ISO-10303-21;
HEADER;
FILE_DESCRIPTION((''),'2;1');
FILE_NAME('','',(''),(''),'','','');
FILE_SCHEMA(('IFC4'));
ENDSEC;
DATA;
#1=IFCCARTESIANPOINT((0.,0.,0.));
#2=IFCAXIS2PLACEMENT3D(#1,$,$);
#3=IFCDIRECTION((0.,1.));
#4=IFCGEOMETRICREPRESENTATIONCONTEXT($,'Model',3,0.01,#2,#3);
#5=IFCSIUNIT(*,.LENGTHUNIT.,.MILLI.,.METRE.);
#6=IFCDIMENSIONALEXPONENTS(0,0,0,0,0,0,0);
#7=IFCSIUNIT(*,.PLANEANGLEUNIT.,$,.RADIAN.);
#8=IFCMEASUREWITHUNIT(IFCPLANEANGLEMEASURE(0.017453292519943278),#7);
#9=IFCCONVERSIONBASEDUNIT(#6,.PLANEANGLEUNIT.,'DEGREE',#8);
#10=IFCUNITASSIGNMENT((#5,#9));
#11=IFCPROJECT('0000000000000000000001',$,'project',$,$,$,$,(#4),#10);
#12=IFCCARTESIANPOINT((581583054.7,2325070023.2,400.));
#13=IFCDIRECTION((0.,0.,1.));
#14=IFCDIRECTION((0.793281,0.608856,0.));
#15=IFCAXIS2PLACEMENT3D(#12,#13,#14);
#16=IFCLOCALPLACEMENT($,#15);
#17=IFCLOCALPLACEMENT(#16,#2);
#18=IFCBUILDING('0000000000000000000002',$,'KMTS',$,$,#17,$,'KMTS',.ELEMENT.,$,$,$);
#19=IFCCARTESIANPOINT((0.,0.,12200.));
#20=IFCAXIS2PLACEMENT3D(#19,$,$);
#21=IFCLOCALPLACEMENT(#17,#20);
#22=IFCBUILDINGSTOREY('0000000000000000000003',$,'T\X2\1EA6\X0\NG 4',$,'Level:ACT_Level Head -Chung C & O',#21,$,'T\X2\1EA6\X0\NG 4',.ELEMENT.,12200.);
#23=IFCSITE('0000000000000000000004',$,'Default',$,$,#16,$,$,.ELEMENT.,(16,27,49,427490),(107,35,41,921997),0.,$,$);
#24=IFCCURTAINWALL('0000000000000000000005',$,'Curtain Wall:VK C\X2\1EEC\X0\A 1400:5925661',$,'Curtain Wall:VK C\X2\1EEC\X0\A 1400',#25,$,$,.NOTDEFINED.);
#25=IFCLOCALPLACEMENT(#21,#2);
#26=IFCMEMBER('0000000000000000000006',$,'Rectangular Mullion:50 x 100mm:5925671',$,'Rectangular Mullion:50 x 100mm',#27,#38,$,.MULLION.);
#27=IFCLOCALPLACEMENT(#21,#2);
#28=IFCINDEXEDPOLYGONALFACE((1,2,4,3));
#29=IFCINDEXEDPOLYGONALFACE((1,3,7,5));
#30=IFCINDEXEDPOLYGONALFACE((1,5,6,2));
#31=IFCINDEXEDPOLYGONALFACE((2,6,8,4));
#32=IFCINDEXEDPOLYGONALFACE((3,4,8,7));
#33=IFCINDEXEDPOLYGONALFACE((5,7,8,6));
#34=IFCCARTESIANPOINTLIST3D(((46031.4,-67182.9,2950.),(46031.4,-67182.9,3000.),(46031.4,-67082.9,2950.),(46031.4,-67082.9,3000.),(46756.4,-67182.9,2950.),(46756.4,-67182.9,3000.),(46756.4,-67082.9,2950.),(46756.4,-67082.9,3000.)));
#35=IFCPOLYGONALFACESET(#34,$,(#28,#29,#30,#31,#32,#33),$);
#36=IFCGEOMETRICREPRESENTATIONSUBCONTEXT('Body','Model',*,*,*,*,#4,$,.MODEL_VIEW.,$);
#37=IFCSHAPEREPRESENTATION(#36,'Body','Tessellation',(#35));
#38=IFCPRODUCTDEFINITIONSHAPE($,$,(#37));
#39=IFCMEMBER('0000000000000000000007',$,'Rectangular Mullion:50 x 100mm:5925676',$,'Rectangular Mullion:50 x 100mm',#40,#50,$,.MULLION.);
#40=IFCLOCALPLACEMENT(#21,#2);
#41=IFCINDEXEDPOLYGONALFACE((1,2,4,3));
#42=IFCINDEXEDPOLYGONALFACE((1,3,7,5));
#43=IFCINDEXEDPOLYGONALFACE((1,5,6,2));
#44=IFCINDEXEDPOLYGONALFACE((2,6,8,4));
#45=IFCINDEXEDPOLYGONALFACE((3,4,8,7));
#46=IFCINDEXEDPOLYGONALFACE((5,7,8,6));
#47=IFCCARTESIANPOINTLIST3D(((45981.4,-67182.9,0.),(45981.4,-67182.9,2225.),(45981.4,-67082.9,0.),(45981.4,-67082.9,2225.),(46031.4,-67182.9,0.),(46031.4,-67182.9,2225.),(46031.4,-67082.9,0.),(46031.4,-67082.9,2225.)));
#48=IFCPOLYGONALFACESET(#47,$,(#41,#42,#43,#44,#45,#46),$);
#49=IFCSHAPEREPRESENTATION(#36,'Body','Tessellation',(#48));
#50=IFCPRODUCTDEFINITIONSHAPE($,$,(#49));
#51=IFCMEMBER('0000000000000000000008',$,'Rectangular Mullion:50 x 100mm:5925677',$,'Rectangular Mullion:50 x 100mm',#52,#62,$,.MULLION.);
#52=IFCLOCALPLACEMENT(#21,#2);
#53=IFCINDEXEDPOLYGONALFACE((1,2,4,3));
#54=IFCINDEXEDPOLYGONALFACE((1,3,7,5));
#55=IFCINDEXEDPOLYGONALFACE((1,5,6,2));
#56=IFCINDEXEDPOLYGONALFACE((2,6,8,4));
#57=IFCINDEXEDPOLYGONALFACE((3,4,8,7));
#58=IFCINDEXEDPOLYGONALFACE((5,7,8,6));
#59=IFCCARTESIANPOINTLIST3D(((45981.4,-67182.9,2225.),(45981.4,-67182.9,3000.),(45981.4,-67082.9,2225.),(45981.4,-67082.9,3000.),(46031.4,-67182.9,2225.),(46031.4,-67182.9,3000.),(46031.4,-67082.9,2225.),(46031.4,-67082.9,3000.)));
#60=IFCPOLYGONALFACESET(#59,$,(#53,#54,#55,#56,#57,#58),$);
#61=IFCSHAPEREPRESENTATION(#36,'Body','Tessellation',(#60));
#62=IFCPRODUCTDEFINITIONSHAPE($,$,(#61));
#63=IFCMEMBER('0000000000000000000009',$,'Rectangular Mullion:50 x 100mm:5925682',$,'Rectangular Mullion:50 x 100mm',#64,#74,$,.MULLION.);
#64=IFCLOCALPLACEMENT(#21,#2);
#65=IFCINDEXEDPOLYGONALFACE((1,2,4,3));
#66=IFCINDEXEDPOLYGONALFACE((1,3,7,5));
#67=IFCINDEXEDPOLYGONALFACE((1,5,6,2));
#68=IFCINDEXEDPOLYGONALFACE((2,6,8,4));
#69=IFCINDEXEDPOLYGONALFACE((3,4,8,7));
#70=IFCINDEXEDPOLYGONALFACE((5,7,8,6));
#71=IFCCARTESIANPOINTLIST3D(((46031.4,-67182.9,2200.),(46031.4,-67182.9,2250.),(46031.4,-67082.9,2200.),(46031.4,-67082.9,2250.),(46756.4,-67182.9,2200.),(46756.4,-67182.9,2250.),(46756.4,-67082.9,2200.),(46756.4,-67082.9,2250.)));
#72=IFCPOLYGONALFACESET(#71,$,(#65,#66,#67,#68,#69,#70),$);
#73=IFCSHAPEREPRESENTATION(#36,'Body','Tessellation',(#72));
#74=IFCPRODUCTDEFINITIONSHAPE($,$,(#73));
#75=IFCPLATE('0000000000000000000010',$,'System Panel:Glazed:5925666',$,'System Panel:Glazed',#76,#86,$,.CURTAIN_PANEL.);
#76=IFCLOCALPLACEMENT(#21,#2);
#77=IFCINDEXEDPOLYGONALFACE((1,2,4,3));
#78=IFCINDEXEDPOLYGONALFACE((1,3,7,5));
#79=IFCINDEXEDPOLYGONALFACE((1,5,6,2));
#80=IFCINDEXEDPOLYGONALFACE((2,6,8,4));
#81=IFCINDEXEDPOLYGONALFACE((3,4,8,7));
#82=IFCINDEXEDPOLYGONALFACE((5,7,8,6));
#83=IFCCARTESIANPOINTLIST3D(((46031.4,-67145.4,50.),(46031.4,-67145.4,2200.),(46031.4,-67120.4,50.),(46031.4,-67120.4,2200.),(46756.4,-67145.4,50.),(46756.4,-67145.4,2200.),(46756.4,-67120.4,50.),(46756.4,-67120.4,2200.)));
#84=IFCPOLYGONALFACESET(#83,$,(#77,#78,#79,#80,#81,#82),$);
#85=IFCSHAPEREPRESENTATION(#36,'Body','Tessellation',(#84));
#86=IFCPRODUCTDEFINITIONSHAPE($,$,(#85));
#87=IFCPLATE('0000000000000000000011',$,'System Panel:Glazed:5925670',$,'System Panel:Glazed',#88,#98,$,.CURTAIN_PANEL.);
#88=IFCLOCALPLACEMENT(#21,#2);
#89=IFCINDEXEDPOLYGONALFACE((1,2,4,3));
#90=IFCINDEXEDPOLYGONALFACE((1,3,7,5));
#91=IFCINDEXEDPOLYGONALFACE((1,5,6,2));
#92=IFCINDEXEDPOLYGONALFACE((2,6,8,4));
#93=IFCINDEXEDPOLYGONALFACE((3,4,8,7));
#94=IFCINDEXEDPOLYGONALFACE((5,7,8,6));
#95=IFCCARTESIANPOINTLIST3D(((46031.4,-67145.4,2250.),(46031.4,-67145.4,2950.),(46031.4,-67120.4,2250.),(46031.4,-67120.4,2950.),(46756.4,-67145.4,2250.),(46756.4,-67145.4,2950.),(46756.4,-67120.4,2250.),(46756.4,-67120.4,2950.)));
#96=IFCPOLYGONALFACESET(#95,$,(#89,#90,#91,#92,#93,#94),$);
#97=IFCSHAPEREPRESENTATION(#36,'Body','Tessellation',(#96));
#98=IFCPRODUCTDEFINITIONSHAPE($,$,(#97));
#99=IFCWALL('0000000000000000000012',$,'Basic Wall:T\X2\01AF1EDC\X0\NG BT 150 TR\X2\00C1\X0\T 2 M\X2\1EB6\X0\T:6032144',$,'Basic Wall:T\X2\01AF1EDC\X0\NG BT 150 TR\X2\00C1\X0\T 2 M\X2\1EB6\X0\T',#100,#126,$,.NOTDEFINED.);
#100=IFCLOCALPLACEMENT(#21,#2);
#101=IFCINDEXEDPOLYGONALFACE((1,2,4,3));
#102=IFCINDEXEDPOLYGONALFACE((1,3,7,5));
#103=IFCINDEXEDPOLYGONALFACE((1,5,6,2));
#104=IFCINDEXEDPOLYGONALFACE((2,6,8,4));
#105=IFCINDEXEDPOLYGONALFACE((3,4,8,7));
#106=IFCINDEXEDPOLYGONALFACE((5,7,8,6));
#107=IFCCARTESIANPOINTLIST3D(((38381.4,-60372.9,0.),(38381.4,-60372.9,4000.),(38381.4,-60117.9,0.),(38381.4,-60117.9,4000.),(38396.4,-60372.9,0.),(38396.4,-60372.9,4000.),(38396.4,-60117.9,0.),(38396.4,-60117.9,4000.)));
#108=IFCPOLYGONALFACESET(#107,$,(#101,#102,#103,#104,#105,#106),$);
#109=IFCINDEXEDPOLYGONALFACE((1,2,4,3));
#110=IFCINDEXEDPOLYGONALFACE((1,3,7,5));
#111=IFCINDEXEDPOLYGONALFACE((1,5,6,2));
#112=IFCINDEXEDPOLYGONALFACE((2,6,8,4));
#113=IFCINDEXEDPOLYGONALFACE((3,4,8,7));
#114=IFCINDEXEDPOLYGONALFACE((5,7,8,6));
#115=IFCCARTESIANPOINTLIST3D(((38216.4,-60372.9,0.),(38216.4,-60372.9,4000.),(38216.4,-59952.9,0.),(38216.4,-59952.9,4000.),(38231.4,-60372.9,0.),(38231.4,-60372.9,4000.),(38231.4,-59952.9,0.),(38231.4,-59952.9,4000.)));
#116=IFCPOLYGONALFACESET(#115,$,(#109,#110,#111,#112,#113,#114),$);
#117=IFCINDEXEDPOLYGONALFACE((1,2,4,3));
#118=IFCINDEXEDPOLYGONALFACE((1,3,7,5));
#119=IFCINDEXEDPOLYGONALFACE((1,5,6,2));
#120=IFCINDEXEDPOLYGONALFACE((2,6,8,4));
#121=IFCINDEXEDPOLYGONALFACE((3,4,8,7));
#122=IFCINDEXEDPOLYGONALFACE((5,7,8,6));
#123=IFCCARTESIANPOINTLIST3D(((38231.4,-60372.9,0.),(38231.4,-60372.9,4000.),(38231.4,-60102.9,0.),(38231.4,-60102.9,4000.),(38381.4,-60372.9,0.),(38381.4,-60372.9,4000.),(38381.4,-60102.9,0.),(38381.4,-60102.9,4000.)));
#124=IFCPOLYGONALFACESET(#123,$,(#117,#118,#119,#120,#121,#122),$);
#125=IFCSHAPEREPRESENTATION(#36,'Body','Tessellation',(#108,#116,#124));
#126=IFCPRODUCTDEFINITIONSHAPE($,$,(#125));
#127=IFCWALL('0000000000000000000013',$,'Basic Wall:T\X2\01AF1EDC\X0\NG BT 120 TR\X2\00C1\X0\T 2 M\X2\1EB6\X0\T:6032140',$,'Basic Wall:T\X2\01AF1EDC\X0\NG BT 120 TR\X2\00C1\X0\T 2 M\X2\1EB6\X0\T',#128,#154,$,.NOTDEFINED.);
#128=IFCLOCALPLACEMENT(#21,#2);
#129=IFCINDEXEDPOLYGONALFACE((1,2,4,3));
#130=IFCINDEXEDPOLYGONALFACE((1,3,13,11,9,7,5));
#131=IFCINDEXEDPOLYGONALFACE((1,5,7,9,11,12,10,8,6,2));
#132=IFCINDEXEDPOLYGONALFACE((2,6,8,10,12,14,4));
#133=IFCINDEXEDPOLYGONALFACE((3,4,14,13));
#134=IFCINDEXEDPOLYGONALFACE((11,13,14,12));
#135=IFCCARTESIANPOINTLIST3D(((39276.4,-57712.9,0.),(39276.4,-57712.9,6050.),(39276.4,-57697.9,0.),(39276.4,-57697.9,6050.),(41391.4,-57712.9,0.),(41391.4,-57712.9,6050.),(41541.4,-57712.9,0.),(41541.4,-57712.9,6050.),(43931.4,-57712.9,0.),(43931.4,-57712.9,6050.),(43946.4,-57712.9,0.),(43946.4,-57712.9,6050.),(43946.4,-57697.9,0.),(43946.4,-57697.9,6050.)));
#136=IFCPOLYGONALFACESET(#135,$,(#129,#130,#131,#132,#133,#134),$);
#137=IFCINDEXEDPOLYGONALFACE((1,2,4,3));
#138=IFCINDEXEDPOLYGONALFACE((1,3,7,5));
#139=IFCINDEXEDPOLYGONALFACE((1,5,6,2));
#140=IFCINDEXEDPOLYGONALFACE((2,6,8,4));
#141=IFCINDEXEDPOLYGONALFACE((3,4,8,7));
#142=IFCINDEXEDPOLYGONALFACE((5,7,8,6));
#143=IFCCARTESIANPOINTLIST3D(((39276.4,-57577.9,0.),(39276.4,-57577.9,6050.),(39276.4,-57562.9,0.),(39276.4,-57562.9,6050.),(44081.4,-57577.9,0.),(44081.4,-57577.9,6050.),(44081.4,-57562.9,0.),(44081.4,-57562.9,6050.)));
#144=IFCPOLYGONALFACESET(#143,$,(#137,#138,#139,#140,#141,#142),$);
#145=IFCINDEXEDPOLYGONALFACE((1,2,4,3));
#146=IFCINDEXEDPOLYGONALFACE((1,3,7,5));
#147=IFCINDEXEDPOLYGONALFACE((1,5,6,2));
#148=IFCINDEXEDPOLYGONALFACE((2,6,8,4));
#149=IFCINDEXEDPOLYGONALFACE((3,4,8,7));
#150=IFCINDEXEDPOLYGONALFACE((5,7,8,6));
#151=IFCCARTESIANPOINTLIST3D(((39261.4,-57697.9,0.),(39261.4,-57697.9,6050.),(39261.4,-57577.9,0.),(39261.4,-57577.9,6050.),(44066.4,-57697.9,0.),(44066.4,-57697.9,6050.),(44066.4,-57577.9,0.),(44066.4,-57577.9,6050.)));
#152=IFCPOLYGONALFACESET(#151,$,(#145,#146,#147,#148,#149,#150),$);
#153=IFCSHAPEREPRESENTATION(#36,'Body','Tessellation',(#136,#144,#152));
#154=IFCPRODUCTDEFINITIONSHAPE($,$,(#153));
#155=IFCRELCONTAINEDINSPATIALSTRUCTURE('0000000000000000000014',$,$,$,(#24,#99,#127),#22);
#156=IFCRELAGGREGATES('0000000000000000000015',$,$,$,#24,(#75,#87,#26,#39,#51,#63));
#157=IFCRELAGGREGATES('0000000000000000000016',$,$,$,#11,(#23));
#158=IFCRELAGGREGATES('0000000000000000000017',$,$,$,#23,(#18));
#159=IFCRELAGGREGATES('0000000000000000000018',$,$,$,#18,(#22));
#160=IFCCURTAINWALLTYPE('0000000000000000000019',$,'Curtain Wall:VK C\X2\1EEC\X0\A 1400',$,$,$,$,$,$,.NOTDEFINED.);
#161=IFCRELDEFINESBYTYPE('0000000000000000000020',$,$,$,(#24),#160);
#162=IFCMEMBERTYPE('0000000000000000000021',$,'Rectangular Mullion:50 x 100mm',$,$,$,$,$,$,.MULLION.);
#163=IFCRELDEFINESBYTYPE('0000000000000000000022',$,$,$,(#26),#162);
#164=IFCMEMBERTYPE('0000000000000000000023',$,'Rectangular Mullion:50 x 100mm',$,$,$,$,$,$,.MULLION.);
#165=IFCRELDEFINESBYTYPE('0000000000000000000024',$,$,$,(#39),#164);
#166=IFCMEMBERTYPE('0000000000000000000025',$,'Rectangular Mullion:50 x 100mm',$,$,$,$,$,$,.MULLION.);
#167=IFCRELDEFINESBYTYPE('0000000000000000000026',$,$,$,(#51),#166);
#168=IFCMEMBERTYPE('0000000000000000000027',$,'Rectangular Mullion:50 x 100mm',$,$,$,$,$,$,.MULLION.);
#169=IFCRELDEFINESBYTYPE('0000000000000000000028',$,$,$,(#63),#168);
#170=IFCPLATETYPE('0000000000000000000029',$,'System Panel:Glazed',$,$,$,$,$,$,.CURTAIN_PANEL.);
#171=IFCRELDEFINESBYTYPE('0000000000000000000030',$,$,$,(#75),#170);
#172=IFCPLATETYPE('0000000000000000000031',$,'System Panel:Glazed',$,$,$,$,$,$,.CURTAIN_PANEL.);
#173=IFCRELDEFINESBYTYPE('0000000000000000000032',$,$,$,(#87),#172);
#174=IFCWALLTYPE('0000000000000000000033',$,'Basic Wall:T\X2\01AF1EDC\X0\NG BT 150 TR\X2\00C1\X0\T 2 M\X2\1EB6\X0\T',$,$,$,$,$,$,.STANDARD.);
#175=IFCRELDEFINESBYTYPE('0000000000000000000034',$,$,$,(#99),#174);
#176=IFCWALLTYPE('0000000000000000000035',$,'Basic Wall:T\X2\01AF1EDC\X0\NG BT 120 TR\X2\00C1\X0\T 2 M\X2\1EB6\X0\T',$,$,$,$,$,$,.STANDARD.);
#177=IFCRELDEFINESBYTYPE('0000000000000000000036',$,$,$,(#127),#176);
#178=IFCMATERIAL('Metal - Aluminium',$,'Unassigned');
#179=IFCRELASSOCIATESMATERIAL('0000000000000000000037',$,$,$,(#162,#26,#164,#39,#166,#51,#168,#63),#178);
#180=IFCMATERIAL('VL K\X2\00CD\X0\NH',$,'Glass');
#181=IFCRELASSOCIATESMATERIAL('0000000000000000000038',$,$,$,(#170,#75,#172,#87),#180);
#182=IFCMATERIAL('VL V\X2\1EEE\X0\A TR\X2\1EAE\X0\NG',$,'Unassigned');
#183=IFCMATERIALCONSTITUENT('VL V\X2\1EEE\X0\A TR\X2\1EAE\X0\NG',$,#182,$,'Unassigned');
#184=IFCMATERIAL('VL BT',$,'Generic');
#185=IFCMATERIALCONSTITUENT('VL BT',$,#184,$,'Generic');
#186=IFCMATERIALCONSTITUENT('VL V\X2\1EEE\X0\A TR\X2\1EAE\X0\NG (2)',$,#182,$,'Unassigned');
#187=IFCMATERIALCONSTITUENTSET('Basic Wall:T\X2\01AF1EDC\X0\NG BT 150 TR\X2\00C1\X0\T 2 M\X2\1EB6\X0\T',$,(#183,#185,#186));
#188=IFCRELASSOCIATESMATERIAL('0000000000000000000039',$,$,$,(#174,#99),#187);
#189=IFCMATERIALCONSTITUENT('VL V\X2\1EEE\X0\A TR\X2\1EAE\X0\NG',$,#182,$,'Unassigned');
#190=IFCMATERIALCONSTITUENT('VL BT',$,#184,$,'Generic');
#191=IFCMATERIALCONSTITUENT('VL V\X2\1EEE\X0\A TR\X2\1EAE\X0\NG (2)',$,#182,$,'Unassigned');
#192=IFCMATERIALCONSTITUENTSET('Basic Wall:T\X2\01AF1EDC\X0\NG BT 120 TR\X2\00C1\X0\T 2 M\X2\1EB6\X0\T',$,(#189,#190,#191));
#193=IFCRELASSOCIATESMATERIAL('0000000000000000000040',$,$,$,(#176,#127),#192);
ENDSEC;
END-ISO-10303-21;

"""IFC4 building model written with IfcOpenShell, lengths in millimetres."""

from ifc_helpers import new_model, entity, si_unit, converted_unit, direction, frame, origin, place, context, subcontext, project, spatial, indexed_curve, outline, extrude, source, transform, mapped, material, constituent, constituent_set, type_object, type_shapes, element, aggregate, save


model = new_model("IFC4")

# Units and contexts
model_context = context("Model", 3, precision=0.01, world=origin(), true_north=direction((0.0, 1.0)))
body_context = subcontext(model_context, "Body", "Model", "MODEL_VIEW")
ifc_project = project(units=[si_unit("LENGTHUNIT", "METRE", prefix="MILLI"), converted_unit("PLANEANGLEUNIT", "DEGREE", entity("IfcPlaneAngleMeasure", 0.017453292519943278), si_unit("PLANEANGLEUNIT", "RADIAN"), dimensions=[0, 0, 0, 0, 0, 0, 0])], contexts=[model_context])

# Site, building, storey
site_placement = place(None, frame((581583054.7, 2325070023.2, 400.0), z_axis=(0.0, 0.0, 1.0), x_axis=(0.793281, 0.608856, 0.0)))
site = spatial("IfcSite", under=ifc_project, at=site_placement, Name="Default", CompositionType="ELEMENT", RefLatitude=(16, 27, 49, 427490), RefLongitude=(107, 35, 41, 921997), RefElevation=0.0)
building_placement = place(site_placement, origin())
building = spatial("IfcBuilding", under=site, at=building_placement, Name="KMTS", LongName="KMTS", CompositionType="ELEMENT")
storey_placement = place(building_placement, frame((0.0, 0.0, 12200.0)))
storey = spatial("IfcBuildingStorey", under=building, at=storey_placement, Name="TẦNG 4", ObjectType="Level:ACT_Level Head -Chung C & O", LongName="TẦNG 4", CompositionType="ELEMENT", Elevation=12200.0)

# Curtain wall, members, plates
curtain_wall_type = type_object("IfcCurtainWallType", Name="Curtain Wall:VK CỬA 1400", PredefinedType="NOTDEFINED")
curtain_wall_placement = place(storey_placement, frame((0.0, 0.0, -12200.0)))
curtain_wall = element("IfcCurtainWall", 1, at=curtain_wall_placement, inside=storey, type_object=curtain_wall_type, Name="Curtain Wall:VK CỬA 1400:5925661", ObjectType="Curtain Wall:VK CỬA 1400", PredefinedType="NOTDEFINED")
ifc_material_1 = material(Name="Metal - Aluminium", Category="Unassigned")
member_type_1 = type_object("IfcMemberType", Name="Rectangular Mullion:50 x 100mm", PredefinedType="MULLION", material=ifc_material_1)
shared_shape_1 = source(origin(), body_context, "Body", "SweptSolid", [
    extrude(outline(indexed_curve([(-25.0, -50.0), (25.0, -50.0), (25.0, 50.0), (-25.0, 50.0), (-25.0, -50.0)], self_intersect=False)), frame((-25.0, 0.0, -725.0), z_axis=(0.0, 0.0, 1.0), x_axis=(-1.0, 0.0, 0.0)), (0.0, 0.0, 1.0), 725.0),
])
type_shapes(member_type_1, [shared_shape_1])
member_1_placement = place(curtain_wall_placement, frame((46031.4, -67132.9, 15200.0), z_axis=(-1.0, 0.0, 0.0), x_axis=(0.0, 0.0, 1.0)))
member_1 = element("IfcMember", 2, at=member_1_placement, type_object=member_type_1, material=ifc_material_1, Name="Rectangular Mullion:50 x 100mm:5925671", ObjectType="Rectangular Mullion:50 x 100mm", PredefinedType="MULLION", context=body_context, shape_type="MappedRepresentation", body=[
    mapped(shared_shape_1, transform((0.0, 0.0, 0.0), scale=1.0)),
])
member_type_2 = type_object("IfcMemberType", Name="Rectangular Mullion:50 x 100mm", PredefinedType="MULLION", material=ifc_material_1)
shared_shape_2 = source(origin(), body_context, "Body", "SweptSolid", [
    extrude(outline(indexed_curve([(-25.0, -50.0), (25.0, -50.0), (25.0, 50.0), (-25.0, 50.0), (-25.0, -50.0)], self_intersect=False)), frame((-25.0, 0.0, -2225.0), z_axis=(0.0, 0.0, 1.0), x_axis=(-1.0, 0.0, 0.0)), (0.0, 0.0, 1.0), 2225.0),
])
type_shapes(member_type_2, [shared_shape_2])
member_2_placement = place(curtain_wall_placement, frame((45981.4, -67132.9, 12200.0), z_axis=(0.0, 0.0, -1.0), x_axis=(-1.0, 0.0, 0.0)))
member_2 = element("IfcMember", 3, at=member_2_placement, type_object=member_type_2, material=ifc_material_1, Name="Rectangular Mullion:50 x 100mm:5925676", ObjectType="Rectangular Mullion:50 x 100mm", PredefinedType="MULLION", context=body_context, shape_type="MappedRepresentation", body=[
    mapped(shared_shape_2, transform((0.0, 0.0, 0.0), scale=1.0)),
])
member_type_3 = type_object("IfcMemberType", Name="Rectangular Mullion:50 x 100mm", PredefinedType="MULLION", material=ifc_material_1)
shared_shape_3 = source(origin(), body_context, "Body", "SweptSolid", [
    extrude(outline(indexed_curve([(-25.0, -50.0), (25.0, -50.0), (25.0, 50.0), (-25.0, 50.0), (-25.0, -50.0)], self_intersect=False)), frame((-25.0, 0.0, -775.0), z_axis=(0.0, 0.0, 1.0), x_axis=(-1.0, 0.0, 0.0)), (0.0, 0.0, 1.0), 775.0),
])
type_shapes(member_type_3, [shared_shape_3])
member_3_placement = place(curtain_wall_placement, frame((45981.4, -67132.9, 14425.0), z_axis=(0.0, 0.0, -1.0), x_axis=(-1.0, 0.0, 0.0)))
member_3 = element("IfcMember", 4, at=member_3_placement, type_object=member_type_3, material=ifc_material_1, Name="Rectangular Mullion:50 x 100mm:5925677", ObjectType="Rectangular Mullion:50 x 100mm", PredefinedType="MULLION", context=body_context, shape_type="MappedRepresentation", body=[
    mapped(shared_shape_3, transform((0.0, 0.0, 0.0), scale=1.0)),
])
member_type_4 = type_object("IfcMemberType", Name="Rectangular Mullion:50 x 100mm", PredefinedType="MULLION", material=ifc_material_1)
shared_shape_4 = source(origin(), body_context, "Body", "SweptSolid", [
    extrude(outline(indexed_curve([(-25.0, -50.0), (25.0, -50.0), (25.0, 50.0), (-25.0, 50.0), (-25.0, -50.0)], self_intersect=False)), frame((0.0, 0.0, -725.0), z_axis=(0.0, 0.0, 1.0), x_axis=(-1.0, 0.0, 0.0)), (0.0, 0.0, 1.0), 725.0),
])
type_shapes(member_type_4, [shared_shape_4])
member_4_placement = place(curtain_wall_placement, frame((46031.4, -67132.9, 14425.0), z_axis=(-1.0, 0.0, 0.0), x_axis=(0.0, 0.0, 1.0)))
member_4 = element("IfcMember", 5, at=member_4_placement, type_object=member_type_4, material=ifc_material_1, Name="Rectangular Mullion:50 x 100mm:5925682", ObjectType="Rectangular Mullion:50 x 100mm", PredefinedType="MULLION", context=body_context, shape_type="MappedRepresentation", body=[
    mapped(shared_shape_4, transform((0.0, 0.0, 0.0), scale=1.0)),
])
ifc_material_2 = material(Name="VL KÍNH", Category="Glass")
plate_type_1 = type_object("IfcPlateType", Name="System Panel:Glazed", PredefinedType="CURTAIN_PANEL", material=ifc_material_2)
shared_shape_5 = source(origin(), body_context, "Body", "SweptSolid", [
    extrude(outline(indexed_curve([(-12.5, -362.5), (12.5, -362.5), (12.5, 362.5), (-12.5, 362.5), (-12.5, -362.5)], self_intersect=False)), frame((0.0, 0.0, 0.0), z_axis=(0.0, 0.0, 1.0), x_axis=(0.0, 1.0, 0.0)), (0.0, 0.0, 1.0), 2150.0),
])
type_shapes(plate_type_1, [shared_shape_5])
plate_1_placement = place(curtain_wall_placement, frame((46393.9, -67132.9, 12250.0), z_axis=(0.0, 0.0, 1.0), x_axis=(-1.0, 0.0, 0.0)))
plate_1 = element("IfcPlate", 6, at=plate_1_placement, type_object=plate_type_1, material=ifc_material_2, Name="System Panel:Glazed:5925666", ObjectType="System Panel:Glazed", PredefinedType="CURTAIN_PANEL", context=body_context, shape_type="MappedRepresentation", body=[
    mapped(shared_shape_5, transform((0.0, 0.0, 0.0), scale=1.0)),
])
plate_type_2 = type_object("IfcPlateType", Name="System Panel:Glazed", PredefinedType="CURTAIN_PANEL", material=ifc_material_2)
shared_shape_6 = source(origin(), body_context, "Body", "SweptSolid", [
    extrude(outline(indexed_curve([(-12.5, -362.5), (12.5, -362.5), (12.5, 362.5), (-12.5, 362.5), (-12.5, -362.5)], self_intersect=False)), frame((0.0, 0.0, 0.0), z_axis=(0.0, 0.0, 1.0), x_axis=(0.0, 1.0, 0.0)), (0.0, 0.0, 1.0), 700.0),
])
type_shapes(plate_type_2, [shared_shape_6])
plate_2_placement = place(curtain_wall_placement, frame((46393.9, -67132.9, 14450.0), z_axis=(0.0, 0.0, 1.0), x_axis=(-1.0, 0.0, 0.0)))
plate_2 = element("IfcPlate", 7, at=plate_2_placement, type_object=plate_type_2, material=ifc_material_2, Name="System Panel:Glazed:5925670", ObjectType="System Panel:Glazed", PredefinedType="CURTAIN_PANEL", context=body_context, shape_type="MappedRepresentation", body=[
    mapped(shared_shape_6, transform((0.0, 0.0, 0.0), scale=1.0)),
])
aggregate(curtain_wall, [plate_1, plate_2, member_1, member_2, member_3, member_4])

# Shared definitions
ifc_material_3 = material(Name="VL VỮA TRẮNG", Category="Unassigned")
ifc_constituent_1 = constituent(ifc_material_3, Name="VL VỮA TRẮNG", Category="Unassigned")
ifc_material_4 = material(Name="VL BT", Category="Generic")
ifc_constituent_2 = constituent(ifc_material_4, Name="VL BT", Category="Generic")
ifc_constituent_3 = constituent(ifc_material_3, Name="VL VỮA TRẮNG (2)", Category="Unassigned")
ifc_constituent_set_1 = constituent_set(constituents=[ifc_constituent_1, ifc_constituent_2, ifc_constituent_3], Name="Basic Wall:TƯỜNG BT 150 TRÁT 2 MẶT")
wall_type_1 = type_object("IfcWallType", Name="Basic Wall:TƯỜNG BT 150 TRÁT 2 MẶT", PredefinedType="STANDARD", material=ifc_constituent_set_1)

# Wall
wall_1_placement = place(storey_placement, frame((38306.4, -60372.9, 0.0), z_axis=(0.0, 0.0, 1.0), x_axis=(0.0, 1.0, 0.0)))
element("IfcWall", 8, at=wall_1_placement, inside=storey, type_object=wall_type_1, material=ifc_constituent_set_1, Name="Basic Wall:TƯỜNG BT 150 TRÁT 2 MẶT:6032144", ObjectType="Basic Wall:TƯỜNG BT 150 TRÁT 2 MẶT", PredefinedType="NOTDEFINED", context=body_context, shape_type="SweptSolid", body=[
    extrude(outline(indexed_curve([(-7.5, -127.5), (7.5, -127.5), (7.5, 127.5), (-7.5, 127.5), (-7.5, -127.5)], self_intersect=False)), frame((127.5, -82.5, 0.0), z_axis=(0.0, 0.0, 1.0), x_axis=(0.0, 1.0, 0.0)), (0.0, 0.0, 1.0), 4000.0),
    extrude(outline(indexed_curve([(-7.5, -210.0), (7.5, -210.0), (7.5, 210.0), (-7.5, 210.0), (-7.5, -210.0)], self_intersect=False)), frame((210.0, 82.5, 0.0), z_axis=(0.0, 0.0, 1.0), x_axis=(0.0, -1.0, 0.0)), (0.0, 0.0, 1.0), 4000.0),
    extrude(outline(indexed_curve([(-135.0, -75.0), (135.0, -75.0), (135.0, 75.0), (-135.0, 75.0), (-135.0, -75.0)], self_intersect=False)), frame((135.0, 0.0, 0.0)), (0.0, 0.0, 1.0), 4000.0),
])

# Shared definitions
ifc_constituent_4 = constituent(ifc_material_3, Name="VL VỮA TRẮNG", Category="Unassigned")
ifc_constituent_5 = constituent(ifc_material_4, Name="VL BT", Category="Generic")
ifc_constituent_6 = constituent(ifc_material_3, Name="VL VỮA TRẮNG (2)", Category="Unassigned")
ifc_constituent_set_2 = constituent_set(constituents=[ifc_constituent_4, ifc_constituent_5, ifc_constituent_6], Name="Basic Wall:TƯỜNG BT 120 TRÁT 2 MẶT")
wall_type_2 = type_object("IfcWallType", Name="Basic Wall:TƯỜNG BT 120 TRÁT 2 MẶT", PredefinedType="STANDARD", material=ifc_constituent_set_2)

# Wall
wall_2_placement = place(storey_placement, frame((39276.4, -57637.9, 0.0)))
element("IfcWall", 9, at=wall_2_placement, inside=storey, type_object=wall_type_2, material=ifc_constituent_set_2, Name="Basic Wall:TƯỜNG BT 120 TRÁT 2 MẶT:6032140", ObjectType="Basic Wall:TƯỜNG BT 120 TRÁT 2 MẶT", PredefinedType="NOTDEFINED", context=body_context, shape_type="SweptSolid", body=[
    extrude(outline(indexed_curve([(-510.0, -4.3), (-360.0, -4.3), (2030.0, -4.3), (2045.0, -4.3), (2045.0, 10.7), (-2625.0, 10.7), (-2625.0, -4.3), (-510.0, -4.3)], self_intersect=False)), frame((2625.0, -70.7, 0.0)), (0.0, 0.0, 1.0), 6050.0),
    extrude(outline(indexed_curve([(-7.5, -2402.5), (7.5, -2402.5), (7.5, 2402.5), (-7.5, 2402.5), (-7.5, -2402.5)], self_intersect=False)), frame((2402.5, 67.5, 0.0), z_axis=(0.0, 0.0, 1.0), x_axis=(0.0, -1.0, 0.0)), (0.0, 0.0, 1.0), 6050.0),
    extrude(outline(indexed_curve([(-2402.5, -60.0), (2402.5, -60.0), (2402.5, 60.0), (-2402.5, 60.0), (-2402.5, -60.0)], self_intersect=False)), frame((2387.5, 0.0, 0.0)), (0.0, 0.0, 1.0), 6050.0),
])

save(model, "model.ifc")
